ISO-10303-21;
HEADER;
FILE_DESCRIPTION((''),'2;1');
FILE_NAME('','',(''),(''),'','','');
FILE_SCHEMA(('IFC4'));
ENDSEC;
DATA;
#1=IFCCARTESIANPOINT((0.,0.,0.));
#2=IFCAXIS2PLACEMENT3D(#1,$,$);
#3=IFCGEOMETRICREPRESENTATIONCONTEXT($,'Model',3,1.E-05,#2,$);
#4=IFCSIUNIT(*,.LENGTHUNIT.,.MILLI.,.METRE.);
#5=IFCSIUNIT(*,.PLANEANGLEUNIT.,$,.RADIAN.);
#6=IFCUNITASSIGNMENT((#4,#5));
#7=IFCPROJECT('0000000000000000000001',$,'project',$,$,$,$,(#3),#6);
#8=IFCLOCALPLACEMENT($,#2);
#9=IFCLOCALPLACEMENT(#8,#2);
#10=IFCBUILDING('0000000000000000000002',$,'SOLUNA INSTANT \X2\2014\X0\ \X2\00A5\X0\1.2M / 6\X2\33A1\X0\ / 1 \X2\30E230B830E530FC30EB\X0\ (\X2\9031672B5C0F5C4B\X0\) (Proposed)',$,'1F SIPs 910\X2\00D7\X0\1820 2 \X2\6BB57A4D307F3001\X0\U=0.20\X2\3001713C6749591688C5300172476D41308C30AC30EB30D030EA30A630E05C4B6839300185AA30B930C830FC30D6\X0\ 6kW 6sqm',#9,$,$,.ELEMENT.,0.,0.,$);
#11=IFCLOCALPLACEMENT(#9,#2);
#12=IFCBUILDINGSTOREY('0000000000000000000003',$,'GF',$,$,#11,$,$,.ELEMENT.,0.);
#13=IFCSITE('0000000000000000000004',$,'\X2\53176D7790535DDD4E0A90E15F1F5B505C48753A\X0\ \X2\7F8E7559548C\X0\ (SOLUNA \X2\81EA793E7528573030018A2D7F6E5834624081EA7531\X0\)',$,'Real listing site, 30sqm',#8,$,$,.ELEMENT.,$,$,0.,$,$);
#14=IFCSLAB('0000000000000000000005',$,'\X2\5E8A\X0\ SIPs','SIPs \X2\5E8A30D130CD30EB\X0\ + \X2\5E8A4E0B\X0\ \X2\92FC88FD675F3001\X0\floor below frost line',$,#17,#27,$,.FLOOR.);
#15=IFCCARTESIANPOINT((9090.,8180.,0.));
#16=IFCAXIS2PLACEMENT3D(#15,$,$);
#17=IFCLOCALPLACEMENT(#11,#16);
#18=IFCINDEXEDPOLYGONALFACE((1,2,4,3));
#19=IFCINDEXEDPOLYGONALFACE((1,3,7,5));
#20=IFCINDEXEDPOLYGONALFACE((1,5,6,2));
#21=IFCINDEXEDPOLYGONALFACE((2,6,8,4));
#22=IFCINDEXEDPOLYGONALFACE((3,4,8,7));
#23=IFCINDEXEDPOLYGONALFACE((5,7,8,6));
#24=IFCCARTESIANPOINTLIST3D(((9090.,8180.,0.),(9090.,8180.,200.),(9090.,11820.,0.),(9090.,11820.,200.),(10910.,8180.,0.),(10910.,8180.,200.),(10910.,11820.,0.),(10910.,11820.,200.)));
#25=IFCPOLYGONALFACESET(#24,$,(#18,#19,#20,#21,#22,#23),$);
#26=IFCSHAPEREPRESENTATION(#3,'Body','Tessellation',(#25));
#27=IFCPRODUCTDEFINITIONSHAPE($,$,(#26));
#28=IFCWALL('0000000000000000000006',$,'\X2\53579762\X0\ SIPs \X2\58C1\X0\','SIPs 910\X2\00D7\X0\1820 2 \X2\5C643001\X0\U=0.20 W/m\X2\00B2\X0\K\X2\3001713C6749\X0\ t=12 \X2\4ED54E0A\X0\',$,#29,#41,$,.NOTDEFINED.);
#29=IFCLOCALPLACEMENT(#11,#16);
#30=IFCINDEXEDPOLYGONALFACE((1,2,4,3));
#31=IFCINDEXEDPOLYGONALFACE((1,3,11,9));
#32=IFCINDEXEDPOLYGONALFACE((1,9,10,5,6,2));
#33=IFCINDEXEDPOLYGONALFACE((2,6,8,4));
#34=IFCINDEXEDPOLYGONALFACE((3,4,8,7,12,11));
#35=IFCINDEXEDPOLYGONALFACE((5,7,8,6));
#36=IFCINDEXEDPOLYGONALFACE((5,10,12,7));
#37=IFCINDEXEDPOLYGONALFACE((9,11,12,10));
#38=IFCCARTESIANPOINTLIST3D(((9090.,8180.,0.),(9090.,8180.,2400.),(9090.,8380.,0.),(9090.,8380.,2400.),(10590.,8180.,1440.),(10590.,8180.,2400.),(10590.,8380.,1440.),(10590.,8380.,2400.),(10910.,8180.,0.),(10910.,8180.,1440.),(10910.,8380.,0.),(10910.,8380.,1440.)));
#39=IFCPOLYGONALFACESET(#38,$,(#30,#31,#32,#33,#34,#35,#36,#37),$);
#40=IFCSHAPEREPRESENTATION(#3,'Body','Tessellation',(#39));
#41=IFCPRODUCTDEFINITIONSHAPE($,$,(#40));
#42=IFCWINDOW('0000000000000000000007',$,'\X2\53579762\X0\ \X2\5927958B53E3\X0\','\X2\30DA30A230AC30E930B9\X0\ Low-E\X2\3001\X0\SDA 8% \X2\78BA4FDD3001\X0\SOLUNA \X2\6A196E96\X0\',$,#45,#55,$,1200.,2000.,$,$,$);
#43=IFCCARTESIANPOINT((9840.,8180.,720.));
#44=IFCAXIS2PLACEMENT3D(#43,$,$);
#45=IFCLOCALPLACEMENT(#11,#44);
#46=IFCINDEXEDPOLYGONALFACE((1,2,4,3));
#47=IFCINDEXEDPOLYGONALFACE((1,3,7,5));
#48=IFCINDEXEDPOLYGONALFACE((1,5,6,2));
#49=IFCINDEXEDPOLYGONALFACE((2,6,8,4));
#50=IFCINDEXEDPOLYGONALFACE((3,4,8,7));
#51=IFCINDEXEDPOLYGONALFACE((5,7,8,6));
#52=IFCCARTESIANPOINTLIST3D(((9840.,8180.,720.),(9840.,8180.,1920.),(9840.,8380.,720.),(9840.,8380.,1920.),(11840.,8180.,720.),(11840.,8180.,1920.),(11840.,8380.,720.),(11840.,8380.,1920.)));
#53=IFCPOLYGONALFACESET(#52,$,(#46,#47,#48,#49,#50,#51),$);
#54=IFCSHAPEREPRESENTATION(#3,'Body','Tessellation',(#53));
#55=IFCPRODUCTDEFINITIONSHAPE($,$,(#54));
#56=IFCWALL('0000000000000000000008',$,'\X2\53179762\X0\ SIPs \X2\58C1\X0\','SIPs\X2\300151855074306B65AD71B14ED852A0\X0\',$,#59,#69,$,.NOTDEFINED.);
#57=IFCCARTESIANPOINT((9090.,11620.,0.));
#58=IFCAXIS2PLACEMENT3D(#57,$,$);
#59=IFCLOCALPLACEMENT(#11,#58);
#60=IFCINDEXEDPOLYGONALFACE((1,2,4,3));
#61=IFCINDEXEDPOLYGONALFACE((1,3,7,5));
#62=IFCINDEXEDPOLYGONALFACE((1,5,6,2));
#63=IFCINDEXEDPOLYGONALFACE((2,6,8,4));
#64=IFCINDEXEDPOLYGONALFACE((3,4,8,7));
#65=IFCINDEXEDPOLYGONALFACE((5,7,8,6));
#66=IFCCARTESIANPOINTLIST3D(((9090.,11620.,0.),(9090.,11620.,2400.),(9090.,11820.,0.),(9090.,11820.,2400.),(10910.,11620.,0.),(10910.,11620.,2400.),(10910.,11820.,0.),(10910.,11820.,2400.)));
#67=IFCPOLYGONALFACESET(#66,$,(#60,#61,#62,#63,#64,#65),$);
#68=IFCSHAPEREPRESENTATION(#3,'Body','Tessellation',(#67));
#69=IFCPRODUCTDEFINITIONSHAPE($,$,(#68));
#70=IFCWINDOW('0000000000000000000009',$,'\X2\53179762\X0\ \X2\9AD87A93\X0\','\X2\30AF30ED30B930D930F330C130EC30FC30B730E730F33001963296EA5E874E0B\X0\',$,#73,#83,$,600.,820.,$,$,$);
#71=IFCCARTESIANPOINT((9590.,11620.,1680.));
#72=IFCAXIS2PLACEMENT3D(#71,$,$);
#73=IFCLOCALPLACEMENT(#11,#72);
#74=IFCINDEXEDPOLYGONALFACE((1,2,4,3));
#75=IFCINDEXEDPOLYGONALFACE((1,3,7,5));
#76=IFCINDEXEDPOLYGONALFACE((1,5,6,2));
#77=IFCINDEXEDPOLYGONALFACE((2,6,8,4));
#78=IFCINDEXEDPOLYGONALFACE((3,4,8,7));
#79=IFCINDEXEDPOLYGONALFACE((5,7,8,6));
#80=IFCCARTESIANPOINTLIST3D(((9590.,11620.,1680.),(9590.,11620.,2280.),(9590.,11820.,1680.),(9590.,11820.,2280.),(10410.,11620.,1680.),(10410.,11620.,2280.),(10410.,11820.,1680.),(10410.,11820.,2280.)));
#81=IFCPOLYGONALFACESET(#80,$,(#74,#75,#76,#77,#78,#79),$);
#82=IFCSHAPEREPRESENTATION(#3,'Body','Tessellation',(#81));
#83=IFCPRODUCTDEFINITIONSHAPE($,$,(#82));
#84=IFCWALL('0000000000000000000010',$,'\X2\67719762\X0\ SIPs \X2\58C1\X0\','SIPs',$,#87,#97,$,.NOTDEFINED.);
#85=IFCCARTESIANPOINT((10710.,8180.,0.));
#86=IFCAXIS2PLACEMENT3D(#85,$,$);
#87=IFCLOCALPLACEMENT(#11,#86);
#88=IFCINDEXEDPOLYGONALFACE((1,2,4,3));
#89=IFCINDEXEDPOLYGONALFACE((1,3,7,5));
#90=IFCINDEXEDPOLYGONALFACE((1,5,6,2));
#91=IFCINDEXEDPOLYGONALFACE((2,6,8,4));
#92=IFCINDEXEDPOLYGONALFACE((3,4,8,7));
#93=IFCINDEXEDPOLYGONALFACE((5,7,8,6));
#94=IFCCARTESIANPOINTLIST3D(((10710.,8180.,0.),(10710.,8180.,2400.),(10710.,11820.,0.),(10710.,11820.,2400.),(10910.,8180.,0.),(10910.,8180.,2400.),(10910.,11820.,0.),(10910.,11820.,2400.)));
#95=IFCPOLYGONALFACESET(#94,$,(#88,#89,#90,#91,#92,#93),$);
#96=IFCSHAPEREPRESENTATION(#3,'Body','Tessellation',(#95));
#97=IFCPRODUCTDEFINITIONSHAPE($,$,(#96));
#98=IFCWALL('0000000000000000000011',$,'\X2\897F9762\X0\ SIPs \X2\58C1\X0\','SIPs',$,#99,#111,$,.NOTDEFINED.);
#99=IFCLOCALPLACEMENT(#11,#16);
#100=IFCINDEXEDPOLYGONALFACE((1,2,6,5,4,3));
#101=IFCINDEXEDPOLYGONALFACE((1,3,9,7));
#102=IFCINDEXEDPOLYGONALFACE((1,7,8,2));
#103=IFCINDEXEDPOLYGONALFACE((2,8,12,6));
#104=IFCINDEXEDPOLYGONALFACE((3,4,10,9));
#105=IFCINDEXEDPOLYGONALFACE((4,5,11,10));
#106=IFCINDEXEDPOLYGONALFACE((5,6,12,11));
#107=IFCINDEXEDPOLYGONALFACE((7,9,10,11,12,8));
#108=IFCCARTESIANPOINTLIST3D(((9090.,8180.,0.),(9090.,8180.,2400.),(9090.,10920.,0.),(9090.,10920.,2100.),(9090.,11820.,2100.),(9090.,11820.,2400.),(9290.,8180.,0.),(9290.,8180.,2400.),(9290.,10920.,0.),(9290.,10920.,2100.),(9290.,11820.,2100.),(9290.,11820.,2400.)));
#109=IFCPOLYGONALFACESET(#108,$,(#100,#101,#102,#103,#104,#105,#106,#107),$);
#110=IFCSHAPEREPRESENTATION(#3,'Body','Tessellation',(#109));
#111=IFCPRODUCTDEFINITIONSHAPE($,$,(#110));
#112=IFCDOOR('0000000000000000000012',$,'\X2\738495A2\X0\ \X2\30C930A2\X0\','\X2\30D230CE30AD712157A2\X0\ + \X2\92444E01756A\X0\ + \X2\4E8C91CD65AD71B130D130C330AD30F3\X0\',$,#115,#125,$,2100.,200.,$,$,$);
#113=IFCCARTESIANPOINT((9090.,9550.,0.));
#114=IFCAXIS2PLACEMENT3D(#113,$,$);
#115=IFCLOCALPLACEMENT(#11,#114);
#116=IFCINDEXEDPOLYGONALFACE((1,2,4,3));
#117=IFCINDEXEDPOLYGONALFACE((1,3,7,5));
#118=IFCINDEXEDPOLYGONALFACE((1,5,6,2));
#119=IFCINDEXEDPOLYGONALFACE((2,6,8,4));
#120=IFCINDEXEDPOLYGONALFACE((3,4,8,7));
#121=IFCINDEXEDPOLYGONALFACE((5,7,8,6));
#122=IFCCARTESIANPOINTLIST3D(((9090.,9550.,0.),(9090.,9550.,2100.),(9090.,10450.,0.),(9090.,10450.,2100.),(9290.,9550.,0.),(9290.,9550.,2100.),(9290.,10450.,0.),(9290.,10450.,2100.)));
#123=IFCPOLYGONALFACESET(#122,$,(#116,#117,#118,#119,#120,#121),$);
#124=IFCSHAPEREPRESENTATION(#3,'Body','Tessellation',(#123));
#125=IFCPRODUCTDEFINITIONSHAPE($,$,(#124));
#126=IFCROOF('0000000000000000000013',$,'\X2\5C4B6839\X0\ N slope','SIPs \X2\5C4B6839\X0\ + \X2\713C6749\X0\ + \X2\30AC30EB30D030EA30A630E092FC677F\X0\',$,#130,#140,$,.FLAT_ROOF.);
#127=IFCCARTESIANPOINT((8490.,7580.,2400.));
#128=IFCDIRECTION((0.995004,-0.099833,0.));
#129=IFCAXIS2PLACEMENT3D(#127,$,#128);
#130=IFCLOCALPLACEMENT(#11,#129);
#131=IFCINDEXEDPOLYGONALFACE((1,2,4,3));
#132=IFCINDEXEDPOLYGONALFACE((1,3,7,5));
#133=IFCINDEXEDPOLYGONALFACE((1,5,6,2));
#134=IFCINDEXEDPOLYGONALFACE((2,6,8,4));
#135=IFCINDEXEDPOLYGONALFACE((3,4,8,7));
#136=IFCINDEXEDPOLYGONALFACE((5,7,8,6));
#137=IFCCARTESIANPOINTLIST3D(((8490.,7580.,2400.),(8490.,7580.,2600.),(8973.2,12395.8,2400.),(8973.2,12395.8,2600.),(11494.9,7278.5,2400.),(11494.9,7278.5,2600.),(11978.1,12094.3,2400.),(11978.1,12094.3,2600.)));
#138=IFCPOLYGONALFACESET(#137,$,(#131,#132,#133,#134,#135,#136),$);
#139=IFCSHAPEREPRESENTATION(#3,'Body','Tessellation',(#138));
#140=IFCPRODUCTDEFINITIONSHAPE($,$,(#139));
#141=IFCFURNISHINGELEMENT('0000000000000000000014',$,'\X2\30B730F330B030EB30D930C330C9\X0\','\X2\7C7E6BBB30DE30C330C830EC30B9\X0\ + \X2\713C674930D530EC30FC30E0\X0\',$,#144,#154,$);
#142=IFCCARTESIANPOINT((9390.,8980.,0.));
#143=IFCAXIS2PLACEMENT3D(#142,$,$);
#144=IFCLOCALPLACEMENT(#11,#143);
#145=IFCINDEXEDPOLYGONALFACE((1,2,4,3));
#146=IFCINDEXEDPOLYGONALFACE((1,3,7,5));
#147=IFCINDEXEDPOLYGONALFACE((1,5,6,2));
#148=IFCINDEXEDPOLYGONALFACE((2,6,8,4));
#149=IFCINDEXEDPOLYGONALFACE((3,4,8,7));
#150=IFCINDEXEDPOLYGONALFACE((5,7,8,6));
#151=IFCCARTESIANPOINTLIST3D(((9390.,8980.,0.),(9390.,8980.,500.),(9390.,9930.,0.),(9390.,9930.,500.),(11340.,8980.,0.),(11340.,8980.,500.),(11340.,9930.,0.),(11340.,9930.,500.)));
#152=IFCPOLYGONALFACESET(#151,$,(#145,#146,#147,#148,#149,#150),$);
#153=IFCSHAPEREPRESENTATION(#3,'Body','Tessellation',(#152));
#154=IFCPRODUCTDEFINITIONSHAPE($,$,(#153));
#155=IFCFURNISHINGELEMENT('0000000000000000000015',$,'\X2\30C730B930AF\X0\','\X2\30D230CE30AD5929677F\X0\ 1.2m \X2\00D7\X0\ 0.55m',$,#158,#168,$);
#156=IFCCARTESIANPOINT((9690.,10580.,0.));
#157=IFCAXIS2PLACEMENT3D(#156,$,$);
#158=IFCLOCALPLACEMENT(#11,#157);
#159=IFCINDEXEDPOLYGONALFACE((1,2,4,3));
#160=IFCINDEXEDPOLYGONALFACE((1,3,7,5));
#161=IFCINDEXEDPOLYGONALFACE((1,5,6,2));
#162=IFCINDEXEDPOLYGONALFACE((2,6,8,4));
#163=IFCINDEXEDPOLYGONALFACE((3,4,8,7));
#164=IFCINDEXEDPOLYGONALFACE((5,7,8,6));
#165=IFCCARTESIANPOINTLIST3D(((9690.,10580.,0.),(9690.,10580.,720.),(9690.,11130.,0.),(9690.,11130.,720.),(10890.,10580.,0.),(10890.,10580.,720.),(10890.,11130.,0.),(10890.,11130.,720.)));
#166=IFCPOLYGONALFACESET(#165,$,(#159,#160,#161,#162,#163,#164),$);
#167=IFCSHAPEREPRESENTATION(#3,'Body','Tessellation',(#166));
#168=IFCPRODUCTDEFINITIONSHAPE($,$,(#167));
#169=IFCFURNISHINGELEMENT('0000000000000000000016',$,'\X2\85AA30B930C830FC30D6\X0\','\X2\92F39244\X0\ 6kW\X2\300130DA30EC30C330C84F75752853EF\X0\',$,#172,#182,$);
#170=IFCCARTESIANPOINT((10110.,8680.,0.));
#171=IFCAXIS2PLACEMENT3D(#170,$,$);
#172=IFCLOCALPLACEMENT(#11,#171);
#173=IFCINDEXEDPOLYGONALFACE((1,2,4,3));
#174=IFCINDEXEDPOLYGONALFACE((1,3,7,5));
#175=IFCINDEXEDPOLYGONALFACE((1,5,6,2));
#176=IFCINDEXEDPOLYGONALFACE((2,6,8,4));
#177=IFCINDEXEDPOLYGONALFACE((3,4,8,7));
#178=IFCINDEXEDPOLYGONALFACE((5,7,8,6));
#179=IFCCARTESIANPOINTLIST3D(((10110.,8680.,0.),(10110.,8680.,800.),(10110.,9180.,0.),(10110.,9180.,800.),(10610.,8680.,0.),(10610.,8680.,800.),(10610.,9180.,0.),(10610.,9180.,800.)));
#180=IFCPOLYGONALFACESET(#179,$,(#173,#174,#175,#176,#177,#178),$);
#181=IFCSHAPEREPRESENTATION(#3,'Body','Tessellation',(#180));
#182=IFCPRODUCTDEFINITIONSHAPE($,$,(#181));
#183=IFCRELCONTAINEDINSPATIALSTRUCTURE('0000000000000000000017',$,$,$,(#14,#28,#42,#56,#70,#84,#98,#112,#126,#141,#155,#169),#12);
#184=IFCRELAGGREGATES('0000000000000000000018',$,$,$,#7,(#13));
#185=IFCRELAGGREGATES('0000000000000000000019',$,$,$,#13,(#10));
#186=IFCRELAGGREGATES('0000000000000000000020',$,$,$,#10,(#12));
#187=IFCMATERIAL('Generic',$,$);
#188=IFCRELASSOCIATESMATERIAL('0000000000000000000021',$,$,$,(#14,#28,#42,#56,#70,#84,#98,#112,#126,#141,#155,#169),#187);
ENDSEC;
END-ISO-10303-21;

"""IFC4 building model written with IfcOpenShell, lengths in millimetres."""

from ifc_helpers import new_model, si_unit, frame, frame_2d, origin, place, context, project, spatial, rectangle, extrude, material, element, fill, save


model = new_model("IFC4")

# Units and contexts
model_context = context("Model", 3, precision=1e-05, world=origin())
ifc_project = project(units=[si_unit("LENGTHUNIT", "METRE", prefix="MILLI"), si_unit("PLANEANGLEUNIT", "RADIAN")], contexts=[model_context])

# Site, building, storey
site_placement = place(None, origin())
site = spatial("IfcSite", under=ifc_project, at=site_placement, Name="北海道川上郡弟子屈町 美留和 (SOLUNA 自社用地、設置場所自由)", ObjectType="Real listing site, 30sqm", CompositionType="ELEMENT", RefElevation=0.0)
building_placement = place(site_placement, origin())
building = spatial("IfcBuilding", under=site, at=building_placement, Name="SOLUNA INSTANT — ¥1.2M / 6㎡ / 1 モジュール (週末小屋) (Proposed)", ObjectType="1F SIPs 910×1820 2 段積み、U=0.20、焼杉外装、片流れガルバリウム屋根、薪ストーブ 6kW 6sqm", CompositionType="ELEMENT", ElevationOfRefHeight=0.0, ElevationOfTerrain=0.0)
storey_placement = place(building_placement, origin())
storey = spatial("IfcBuildingStorey", under=building, at=storey_placement, Name="GF", CompositionType="ELEMENT", Elevation=0.0)

# Slab
ifc_material = material(Name="Generic")
slab_placement = place(storey_placement, frame((9090.0, 8180.0, 0.0)))
element("IfcSlab", 1, at=slab_placement, inside=storey, material=ifc_material, Name="床 SIPs", Description="SIPs 床パネル + 床下 鋼製束、floor below frost line", PredefinedType="FLOOR", context=model_context, shape_type="SweptSolid", body=[
    extrude(rectangle(XDim=1820.0, YDim=3640.0, at=frame_2d((910.0, 1820.0))), frame((9090.0, 8180.0, 0.0)), (0.0, 0.0, 1.0), 200.0),
])

# Walls, openings, windows
wall_1_placement = place(storey_placement, frame((9090.0, 8180.0, 0.0)))
wall_1 = element("IfcWall", 2, at=wall_1_placement, inside=storey, material=ifc_material, Name="南面 SIPs 壁", Description="SIPs 910×1820 2 層、U=0.20 W/m²K、焼杉 t=12 仕上", PredefinedType="NOTDEFINED", context=model_context, shape_type="SweptSolid", body=[
    extrude(rectangle(XDim=1820.0, YDim=200.0, at=frame_2d((910.0, 100.0))), frame((9090.0, 8180.0, 0.0)), (0.0, 0.0, 1.0), 2400.0),
])
opening_1_placement = place(storey_placement, frame((9840.0, 8180.0, 720.0)))
opening_1 = element("IfcOpeningElement", 3, at=opening_1_placement, cuts=wall_1, PredefinedType="NOTDEFINED", context=model_context, shape_type="SweptSolid", body=[
    extrude(rectangle(XDim=2000.0, YDim=200.0, at=frame_2d((1000.0, 100.0))), frame((9840.0, 8180.0, 720.0)), (0.0, 0.0, 1.0), 1200.0),
])
window_1_placement = place(storey_placement, frame((9840.0, 8180.0, 720.0)))
window_1 = element("IfcWindow", 4, at=window_1_placement, inside=storey, material=ifc_material, Name="南面 大開口", Description="ペアガラス Low-E、SDA 8% 確保、SOLUNA 標準", OverallHeight=1200.0, OverallWidth=2000.0, context=model_context, shape_type="SweptSolid", body=[
    extrude(rectangle(XDim=2000.0, YDim=200.0, at=frame_2d((1000.0, 100.0))), frame((9840.0, 8180.0, 720.0)), (0.0, 0.0, 1.0), 1200.0),
])
fill(opening_1, window_1)
wall_2_placement = place(storey_placement, frame((9090.0, 11620.0, 0.0)))
wall_2 = element("IfcWall", 5, at=wall_2_placement, inside=storey, material=ifc_material, Name="北面 SIPs 壁", Description="SIPs、内側に断熱付加", PredefinedType="NOTDEFINED", context=model_context, shape_type="SweptSolid", body=[
    extrude(rectangle(XDim=1820.0, YDim=200.0, at=frame_2d((910.0, 100.0))), frame((9090.0, 11620.0, 0.0)), (0.0, 0.0, 1.0), 2400.0),
])
opening_2_placement = place(storey_placement, frame((9590.0, 11620.0, 1680.0)))
opening_2 = element("IfcOpeningElement", 6, at=opening_2_placement, cuts=wall_2, PredefinedType="NOTDEFINED", context=model_context, shape_type="SweptSolid", body=[
    extrude(rectangle(XDim=820.0, YDim=200.0, at=frame_2d((410.0, 100.0))), frame((9590.0, 11620.0, 1680.0)), (0.0, 0.0, 1.0), 600.0),
])
window_2_placement = place(storey_placement, frame((9590.0, 11620.0, 1680.0)))
window_2 = element("IfcWindow", 7, at=window_2_placement, inside=storey, material=ifc_material, Name="北面 高窓", Description="クロスベンチレーション、防雪庇下", OverallHeight=600.0, OverallWidth=820.0, context=model_context, shape_type="SweptSolid", body=[
    extrude(rectangle(XDim=820.0, YDim=200.0, at=frame_2d((410.0, 100.0))), frame((9590.0, 11620.0, 1680.0)), (0.0, 0.0, 1.0), 600.0),
])
fill(opening_2, window_2)

# Wall
wall_3_placement = place(storey_placement, frame((10710.0, 8180.0, 0.0)))
element("IfcWall", 8, at=wall_3_placement, inside=storey, material=ifc_material, Name="東面 SIPs 壁", Description="SIPs", PredefinedType="NOTDEFINED", context=model_context, shape_type="SweptSolid", body=[
    extrude(rectangle(XDim=200.0, YDim=3640.0, at=frame_2d((100.0, 1820.0))), frame((10710.0, 8180.0, 0.0)), (0.0, 0.0, 1.0), 2400.0),
])

# Wall, opening, door
wall_4_placement = place(storey_placement, frame((9090.0, 8180.0, 0.0)))
wall_4 = element("IfcWall", 9, at=wall_4_placement, inside=storey, material=ifc_material, Name="西面 SIPs 壁", Description="SIPs", PredefinedType="NOTDEFINED", context=model_context, shape_type="SweptSolid", body=[
    extrude(rectangle(XDim=200.0, YDim=3640.0, at=frame_2d((100.0, 1820.0))), frame((9090.0, 8180.0, 0.0)), (0.0, 0.0, 1.0), 2400.0),
])
opening_3_placement = place(storey_placement, frame((9090.0, 9550.0, 0.0)))
opening_3 = element("IfcOpeningElement", 10, at=opening_3_placement, cuts=wall_4, PredefinedType="NOTDEFINED", context=model_context, shape_type="SweptSolid", body=[
    extrude(rectangle(XDim=200.0, YDim=900.0, at=frame_2d((100.0, 450.0))), frame((9090.0, 9550.0, 0.0)), (0.0, 0.0, 1.0), 2100.0),
])
door_placement = place(storey_placement, frame((9090.0, 9550.0, 0.0)))
door = element("IfcDoor", 11, at=door_placement, inside=storey, material=ifc_material, Name="玄関 ドア", Description="ヒノキ無垢 + 鉄丁番 + 二重断熱パッキン", OverallHeight=2100.0, OverallWidth=200.0, context=model_context, shape_type="SweptSolid", body=[
    extrude(rectangle(XDim=200.0, YDim=900.0, at=frame_2d((100.0, 450.0))), frame((9090.0, 9550.0, 0.0)), (0.0, 0.0, 1.0), 2100.0),
])
fill(opening_3, door)

# Roof
roof_placement = place(storey_placement, frame((8490.0, 7580.0, 2400.0), x_axis=(0.995004, -0.099833, 0.0)))
element("IfcRoof", 12, at=roof_placement, inside=storey, material=ifc_material, Name="屋根 N slope", Description="SIPs 屋根 + 焼杉 + ガルバリウム鋼板", PredefinedType="FLAT_ROOF", context=model_context, shape_type="SweptSolid", body=[
    extrude(rectangle(XDim=3020.0, YDim=4840.0, at=frame_2d((1510.0, 2420.0))), frame((8490.0, 7580.0, 2400.0), x_axis=(0.995004, -0.099833, 0.0)), (0.0, 0.0, 1.0), 200.0),
])

# Furnishing elements
furnishing_1_placement = place(storey_placement, frame((9390.0, 8980.0, 0.0)))
element("IfcFurnishingElement", 13, at=furnishing_1_placement, inside=storey, material=ifc_material, Name="シングルベッド", Description="籾殻マットレス + 焼杉フレーム", context=model_context, shape_type="SweptSolid", body=[
    extrude(rectangle(XDim=1950.0, YDim=950.0, at=frame_2d((975.0, 475.0))), frame((9390.0, 8980.0, 0.0)), (0.0, 0.0, 1.0), 500.0),
])
furnishing_2_placement = place(storey_placement, frame((9690.0, 10580.0, 0.0)))
element("IfcFurnishingElement", 14, at=furnishing_2_placement, inside=storey, material=ifc_material, Name="デスク", Description="ヒノキ天板 1.2m × 0.55m", context=model_context, shape_type="SweptSolid", body=[
    extrude(rectangle(XDim=1200.0, YDim=550.0, at=frame_2d((600.0, 275.0))), frame((9690.0, 10580.0, 0.0)), (0.0, 0.0, 1.0), 720.0),
])
furnishing_3_placement = place(storey_placement, frame((10110.0, 8680.0, 0.0)))
element("IfcFurnishingElement", 15, at=furnishing_3_placement, inside=storey, material=ifc_material, Name="薪ストーブ", Description="鋳鉄 6kW、ペレット併用可", context=model_context, shape_type="SweptSolid", body=[
    extrude(rectangle(XDim=500.0, YDim=500.0, at=frame_2d((250.0, 250.0))), frame((10110.0, 8680.0, 0.0)), (0.0, 0.0, 1.0), 800.0),
])

save(model, "model.ifc")
